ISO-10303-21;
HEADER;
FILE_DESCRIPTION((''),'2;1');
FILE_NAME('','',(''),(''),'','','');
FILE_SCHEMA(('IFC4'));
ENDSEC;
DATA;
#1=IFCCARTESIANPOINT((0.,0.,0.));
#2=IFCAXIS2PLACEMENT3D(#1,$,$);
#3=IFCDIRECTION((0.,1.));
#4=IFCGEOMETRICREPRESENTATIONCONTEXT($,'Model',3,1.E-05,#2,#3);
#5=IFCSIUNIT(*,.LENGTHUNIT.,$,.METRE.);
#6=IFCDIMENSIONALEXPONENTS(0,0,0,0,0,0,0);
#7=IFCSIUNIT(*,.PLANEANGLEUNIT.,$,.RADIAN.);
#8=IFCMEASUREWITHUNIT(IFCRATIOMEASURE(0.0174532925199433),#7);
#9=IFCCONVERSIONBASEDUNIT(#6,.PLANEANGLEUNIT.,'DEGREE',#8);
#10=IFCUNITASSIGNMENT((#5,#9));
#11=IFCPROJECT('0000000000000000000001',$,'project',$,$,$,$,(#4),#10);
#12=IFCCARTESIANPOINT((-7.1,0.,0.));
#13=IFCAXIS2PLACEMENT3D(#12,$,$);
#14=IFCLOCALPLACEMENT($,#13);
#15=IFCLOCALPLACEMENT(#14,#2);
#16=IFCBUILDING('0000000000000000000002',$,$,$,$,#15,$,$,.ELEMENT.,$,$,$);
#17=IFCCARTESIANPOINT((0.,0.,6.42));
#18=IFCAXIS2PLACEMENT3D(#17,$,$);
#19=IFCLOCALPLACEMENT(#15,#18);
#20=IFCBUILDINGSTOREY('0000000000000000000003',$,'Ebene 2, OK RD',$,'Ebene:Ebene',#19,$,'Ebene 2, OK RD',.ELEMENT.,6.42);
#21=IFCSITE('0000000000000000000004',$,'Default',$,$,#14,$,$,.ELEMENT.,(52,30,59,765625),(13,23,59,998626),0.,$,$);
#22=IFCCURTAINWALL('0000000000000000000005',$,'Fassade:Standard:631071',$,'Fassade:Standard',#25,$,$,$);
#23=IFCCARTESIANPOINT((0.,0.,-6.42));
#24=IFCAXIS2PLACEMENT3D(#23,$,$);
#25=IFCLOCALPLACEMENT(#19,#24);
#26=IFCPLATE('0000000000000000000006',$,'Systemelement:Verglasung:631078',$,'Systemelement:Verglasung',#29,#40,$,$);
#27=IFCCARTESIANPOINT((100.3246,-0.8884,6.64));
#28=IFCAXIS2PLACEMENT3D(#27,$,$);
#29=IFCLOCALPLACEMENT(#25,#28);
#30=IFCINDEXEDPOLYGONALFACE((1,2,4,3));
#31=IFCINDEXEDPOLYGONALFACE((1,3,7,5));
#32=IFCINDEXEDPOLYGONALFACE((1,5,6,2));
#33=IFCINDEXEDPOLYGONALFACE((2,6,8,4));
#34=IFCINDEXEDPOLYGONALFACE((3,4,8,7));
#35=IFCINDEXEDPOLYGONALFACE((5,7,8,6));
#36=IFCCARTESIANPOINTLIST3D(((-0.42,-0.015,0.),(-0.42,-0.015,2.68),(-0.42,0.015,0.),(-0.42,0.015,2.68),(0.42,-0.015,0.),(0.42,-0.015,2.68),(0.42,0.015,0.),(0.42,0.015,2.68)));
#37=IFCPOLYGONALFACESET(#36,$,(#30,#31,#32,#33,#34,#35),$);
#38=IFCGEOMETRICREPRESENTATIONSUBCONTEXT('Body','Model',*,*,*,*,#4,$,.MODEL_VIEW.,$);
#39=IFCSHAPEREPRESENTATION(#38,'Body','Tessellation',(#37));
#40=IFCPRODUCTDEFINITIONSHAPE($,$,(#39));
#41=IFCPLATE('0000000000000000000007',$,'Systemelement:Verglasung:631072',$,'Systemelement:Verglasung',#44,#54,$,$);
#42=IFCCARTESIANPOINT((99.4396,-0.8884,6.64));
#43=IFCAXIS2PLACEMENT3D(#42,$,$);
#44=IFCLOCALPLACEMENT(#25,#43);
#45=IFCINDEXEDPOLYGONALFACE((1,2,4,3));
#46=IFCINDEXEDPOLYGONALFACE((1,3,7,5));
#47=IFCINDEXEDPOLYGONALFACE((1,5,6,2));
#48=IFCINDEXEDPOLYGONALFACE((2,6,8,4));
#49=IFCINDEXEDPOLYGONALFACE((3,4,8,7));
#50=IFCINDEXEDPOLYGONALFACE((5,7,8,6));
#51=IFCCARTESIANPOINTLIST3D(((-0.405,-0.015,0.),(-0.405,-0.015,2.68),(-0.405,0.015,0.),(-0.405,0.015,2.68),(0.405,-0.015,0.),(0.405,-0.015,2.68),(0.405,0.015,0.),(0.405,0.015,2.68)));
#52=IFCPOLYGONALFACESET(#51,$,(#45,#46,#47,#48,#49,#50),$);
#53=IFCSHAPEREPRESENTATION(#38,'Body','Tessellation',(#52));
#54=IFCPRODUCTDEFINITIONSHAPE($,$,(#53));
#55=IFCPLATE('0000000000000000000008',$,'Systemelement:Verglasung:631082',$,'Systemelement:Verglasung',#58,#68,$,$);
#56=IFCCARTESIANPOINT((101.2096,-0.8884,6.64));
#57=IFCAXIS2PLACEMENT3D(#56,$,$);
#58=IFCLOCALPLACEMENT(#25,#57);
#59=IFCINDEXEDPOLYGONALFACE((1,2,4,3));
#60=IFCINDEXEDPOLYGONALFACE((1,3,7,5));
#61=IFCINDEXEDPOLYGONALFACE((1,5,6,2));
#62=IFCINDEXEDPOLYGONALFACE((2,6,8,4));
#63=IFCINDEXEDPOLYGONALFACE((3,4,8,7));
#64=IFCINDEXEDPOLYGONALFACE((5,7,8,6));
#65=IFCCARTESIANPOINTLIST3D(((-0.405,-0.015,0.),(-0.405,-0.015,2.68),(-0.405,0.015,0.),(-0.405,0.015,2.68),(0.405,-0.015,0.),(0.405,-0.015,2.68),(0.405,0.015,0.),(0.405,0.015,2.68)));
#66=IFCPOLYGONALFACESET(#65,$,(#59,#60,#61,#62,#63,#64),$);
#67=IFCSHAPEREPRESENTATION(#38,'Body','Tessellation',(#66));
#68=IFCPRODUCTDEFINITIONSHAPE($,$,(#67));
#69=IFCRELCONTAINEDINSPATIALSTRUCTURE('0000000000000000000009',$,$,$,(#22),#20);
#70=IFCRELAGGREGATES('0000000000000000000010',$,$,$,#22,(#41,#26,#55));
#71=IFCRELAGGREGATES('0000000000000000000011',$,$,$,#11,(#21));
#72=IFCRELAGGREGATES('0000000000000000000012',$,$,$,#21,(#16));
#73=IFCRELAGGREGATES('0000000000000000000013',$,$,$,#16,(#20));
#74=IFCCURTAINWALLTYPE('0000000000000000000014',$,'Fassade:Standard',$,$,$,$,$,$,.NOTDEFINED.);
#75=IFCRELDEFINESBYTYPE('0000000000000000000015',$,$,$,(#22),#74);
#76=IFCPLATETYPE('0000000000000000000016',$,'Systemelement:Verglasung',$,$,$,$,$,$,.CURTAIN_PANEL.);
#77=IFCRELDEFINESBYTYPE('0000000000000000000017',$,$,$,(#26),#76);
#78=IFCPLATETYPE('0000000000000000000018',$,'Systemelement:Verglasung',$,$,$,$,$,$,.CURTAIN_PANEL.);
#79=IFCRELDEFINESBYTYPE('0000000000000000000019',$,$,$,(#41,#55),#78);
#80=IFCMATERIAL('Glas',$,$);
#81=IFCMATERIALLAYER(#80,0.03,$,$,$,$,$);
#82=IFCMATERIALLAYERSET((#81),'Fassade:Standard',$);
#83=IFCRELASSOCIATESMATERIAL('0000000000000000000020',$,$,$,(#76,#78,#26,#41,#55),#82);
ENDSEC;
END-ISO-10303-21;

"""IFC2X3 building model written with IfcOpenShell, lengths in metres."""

from ifc_helpers import new_model, entity, si_unit, converted_unit, direction, frame, origin, origin_2d_with_axis, place, context, subcontext, project, spatial, rectangle, extrude, source, transform, mapped, material, layer, layer_set, layer_usage, type_object, type_shapes, element, aggregate, save


model = new_model("IFC2X3")

# Units and contexts
model_context = context("Model", 3, precision=1e-05, world=origin(), true_north=direction((0.0, 1.0)))
body_context = subcontext(model_context, "Body", "Model", "MODEL_VIEW")
ifc_project = project(units=[si_unit("LENGTHUNIT", "METRE"), converted_unit("PLANEANGLEUNIT", "DEGREE", entity("IfcRatioMeasure", 0.0174532925199433), si_unit("PLANEANGLEUNIT", "RADIAN"), dimensions=[0, 0, 0, 0, 0, 0, 0])], contexts=[model_context])

# Site, building, storey
site_placement = place(None, frame((-7.1, 0.0, 0.0)))
site = spatial("IfcSite", under=ifc_project, at=site_placement, Name="Default", CompositionType="ELEMENT", RefLatitude=(52, 30, 59, 765625), RefLongitude=(13, 23, 59, 998626), RefElevation=0.0)
building_placement = place(site_placement, origin())
building = spatial("IfcBuilding", under=site, at=building_placement, CompositionType="ELEMENT")
storey_placement = place(building_placement, frame((0.0, 0.0, 6.42)))
storey = spatial("IfcBuildingStorey", under=building, at=storey_placement, Name="Ebene 2, OK RD", ObjectType="Ebene:Ebene", LongName="Ebene 2, OK RD", CompositionType="ELEMENT", Elevation=6.42)

# Curtain wall
curtain_wall_type = type_object("IfcCurtainWallType", Name="Fassade:Standard", PredefinedType="NOTDEFINED")
curtain_wall_placement = place(storey_placement, frame((0.0, 0.0, -6.42)))
curtain_wall = element("IfcCurtainWall", 1, at=curtain_wall_placement, inside=storey, type_object=curtain_wall_type, Name="Fassade:Standard:631071", ObjectType="Fassade:Standard")

# Plates
ifc_material_1 = material(Name="Glas")
ifc_layer_1 = layer(ifc_material_1, 0.03)
ifc_layer_set_1 = layer_set([ifc_layer_1], Name="Fassade:Standard")
ifc_layer_usage_1 = layer_usage(ifc_layer_set_1, "AXIS3", "POSITIVE", 0.0)
plate_type_1 = type_object("IfcPlateType", Name="Systemelement:Verglasung", PredefinedType="CURTAIN_PANEL", material=ifc_layer_set_1)
shared_shape_1 = source(origin(), body_context, "Body", "SweptSolid", [
    extrude(rectangle(XDim=0.03, YDim=0.84, at=origin_2d_with_axis()), frame((0.0, 0.0, 0.0), z_axis=(0.0, 0.0, 1.0), x_axis=(0.0, 1.0, 0.0)), (0.0, 0.0, 1.0), 2.68),
])
type_shapes(plate_type_1, [shared_shape_1])
plate_1_placement = place(curtain_wall_placement, frame((100.3246, -0.8884, 6.64)))
plate_1 = element("IfcPlate", 2, at=plate_1_placement, type_object=plate_type_1, material=ifc_layer_usage_1, Name="Systemelement:Verglasung:631078", ObjectType="Systemelement:Verglasung", context=body_context, shape_type="MappedRepresentation", body=[
    mapped(shared_shape_1, transform((0.0, 0.0, 0.0), scale=1.0)),
])
ifc_layer_usage_2 = layer_usage(ifc_layer_set_1, "AXIS3", "POSITIVE", 0.0)
plate_type_2 = type_object("IfcPlateType", Name="Systemelement:Verglasung", PredefinedType="CURTAIN_PANEL", material=ifc_layer_set_1)
shared_shape_2 = source(origin(), body_context, "Body", "SweptSolid", [
    extrude(rectangle(XDim=0.03, YDim=0.81, at=origin_2d_with_axis()), frame((0.0, 0.0, 0.0), z_axis=(0.0, 0.0, 1.0), x_axis=(0.0, 1.0, 0.0)), (0.0, 0.0, 1.0), 2.68),
])
type_shapes(plate_type_2, [shared_shape_2])
plate_2_placement = place(curtain_wall_placement, frame((99.4396, -0.8884, 6.64)))
plate_2 = element("IfcPlate", 3, at=plate_2_placement, type_object=plate_type_2, material=ifc_layer_usage_2, Name="Systemelement:Verglasung:631072", ObjectType="Systemelement:Verglasung", context=body_context, shape_type="MappedRepresentation", body=[
    mapped(shared_shape_2, transform((0.0, 0.0, 0.0), scale=1.0)),
])
ifc_layer_usage_3 = layer_usage(ifc_layer_set_1, "AXIS3", "POSITIVE", 0.0)
plate_3_placement = place(curtain_wall_placement, frame((101.2096, -0.8884, 6.64)))
plate_3 = element("IfcPlate", 4, at=plate_3_placement, type_object=plate_type_2, material=ifc_layer_usage_3, Name="Systemelement:Verglasung:631082", ObjectType="Systemelement:Verglasung", context=body_context, shape_type="MappedRepresentation", body=[
    mapped(shared_shape_2, transform((0.0, 0.0, 0.0), scale=1.0)),
])
aggregate(curtain_wall, [plate_2, plate_1, plate_3])

save(model, "model.ifc")
